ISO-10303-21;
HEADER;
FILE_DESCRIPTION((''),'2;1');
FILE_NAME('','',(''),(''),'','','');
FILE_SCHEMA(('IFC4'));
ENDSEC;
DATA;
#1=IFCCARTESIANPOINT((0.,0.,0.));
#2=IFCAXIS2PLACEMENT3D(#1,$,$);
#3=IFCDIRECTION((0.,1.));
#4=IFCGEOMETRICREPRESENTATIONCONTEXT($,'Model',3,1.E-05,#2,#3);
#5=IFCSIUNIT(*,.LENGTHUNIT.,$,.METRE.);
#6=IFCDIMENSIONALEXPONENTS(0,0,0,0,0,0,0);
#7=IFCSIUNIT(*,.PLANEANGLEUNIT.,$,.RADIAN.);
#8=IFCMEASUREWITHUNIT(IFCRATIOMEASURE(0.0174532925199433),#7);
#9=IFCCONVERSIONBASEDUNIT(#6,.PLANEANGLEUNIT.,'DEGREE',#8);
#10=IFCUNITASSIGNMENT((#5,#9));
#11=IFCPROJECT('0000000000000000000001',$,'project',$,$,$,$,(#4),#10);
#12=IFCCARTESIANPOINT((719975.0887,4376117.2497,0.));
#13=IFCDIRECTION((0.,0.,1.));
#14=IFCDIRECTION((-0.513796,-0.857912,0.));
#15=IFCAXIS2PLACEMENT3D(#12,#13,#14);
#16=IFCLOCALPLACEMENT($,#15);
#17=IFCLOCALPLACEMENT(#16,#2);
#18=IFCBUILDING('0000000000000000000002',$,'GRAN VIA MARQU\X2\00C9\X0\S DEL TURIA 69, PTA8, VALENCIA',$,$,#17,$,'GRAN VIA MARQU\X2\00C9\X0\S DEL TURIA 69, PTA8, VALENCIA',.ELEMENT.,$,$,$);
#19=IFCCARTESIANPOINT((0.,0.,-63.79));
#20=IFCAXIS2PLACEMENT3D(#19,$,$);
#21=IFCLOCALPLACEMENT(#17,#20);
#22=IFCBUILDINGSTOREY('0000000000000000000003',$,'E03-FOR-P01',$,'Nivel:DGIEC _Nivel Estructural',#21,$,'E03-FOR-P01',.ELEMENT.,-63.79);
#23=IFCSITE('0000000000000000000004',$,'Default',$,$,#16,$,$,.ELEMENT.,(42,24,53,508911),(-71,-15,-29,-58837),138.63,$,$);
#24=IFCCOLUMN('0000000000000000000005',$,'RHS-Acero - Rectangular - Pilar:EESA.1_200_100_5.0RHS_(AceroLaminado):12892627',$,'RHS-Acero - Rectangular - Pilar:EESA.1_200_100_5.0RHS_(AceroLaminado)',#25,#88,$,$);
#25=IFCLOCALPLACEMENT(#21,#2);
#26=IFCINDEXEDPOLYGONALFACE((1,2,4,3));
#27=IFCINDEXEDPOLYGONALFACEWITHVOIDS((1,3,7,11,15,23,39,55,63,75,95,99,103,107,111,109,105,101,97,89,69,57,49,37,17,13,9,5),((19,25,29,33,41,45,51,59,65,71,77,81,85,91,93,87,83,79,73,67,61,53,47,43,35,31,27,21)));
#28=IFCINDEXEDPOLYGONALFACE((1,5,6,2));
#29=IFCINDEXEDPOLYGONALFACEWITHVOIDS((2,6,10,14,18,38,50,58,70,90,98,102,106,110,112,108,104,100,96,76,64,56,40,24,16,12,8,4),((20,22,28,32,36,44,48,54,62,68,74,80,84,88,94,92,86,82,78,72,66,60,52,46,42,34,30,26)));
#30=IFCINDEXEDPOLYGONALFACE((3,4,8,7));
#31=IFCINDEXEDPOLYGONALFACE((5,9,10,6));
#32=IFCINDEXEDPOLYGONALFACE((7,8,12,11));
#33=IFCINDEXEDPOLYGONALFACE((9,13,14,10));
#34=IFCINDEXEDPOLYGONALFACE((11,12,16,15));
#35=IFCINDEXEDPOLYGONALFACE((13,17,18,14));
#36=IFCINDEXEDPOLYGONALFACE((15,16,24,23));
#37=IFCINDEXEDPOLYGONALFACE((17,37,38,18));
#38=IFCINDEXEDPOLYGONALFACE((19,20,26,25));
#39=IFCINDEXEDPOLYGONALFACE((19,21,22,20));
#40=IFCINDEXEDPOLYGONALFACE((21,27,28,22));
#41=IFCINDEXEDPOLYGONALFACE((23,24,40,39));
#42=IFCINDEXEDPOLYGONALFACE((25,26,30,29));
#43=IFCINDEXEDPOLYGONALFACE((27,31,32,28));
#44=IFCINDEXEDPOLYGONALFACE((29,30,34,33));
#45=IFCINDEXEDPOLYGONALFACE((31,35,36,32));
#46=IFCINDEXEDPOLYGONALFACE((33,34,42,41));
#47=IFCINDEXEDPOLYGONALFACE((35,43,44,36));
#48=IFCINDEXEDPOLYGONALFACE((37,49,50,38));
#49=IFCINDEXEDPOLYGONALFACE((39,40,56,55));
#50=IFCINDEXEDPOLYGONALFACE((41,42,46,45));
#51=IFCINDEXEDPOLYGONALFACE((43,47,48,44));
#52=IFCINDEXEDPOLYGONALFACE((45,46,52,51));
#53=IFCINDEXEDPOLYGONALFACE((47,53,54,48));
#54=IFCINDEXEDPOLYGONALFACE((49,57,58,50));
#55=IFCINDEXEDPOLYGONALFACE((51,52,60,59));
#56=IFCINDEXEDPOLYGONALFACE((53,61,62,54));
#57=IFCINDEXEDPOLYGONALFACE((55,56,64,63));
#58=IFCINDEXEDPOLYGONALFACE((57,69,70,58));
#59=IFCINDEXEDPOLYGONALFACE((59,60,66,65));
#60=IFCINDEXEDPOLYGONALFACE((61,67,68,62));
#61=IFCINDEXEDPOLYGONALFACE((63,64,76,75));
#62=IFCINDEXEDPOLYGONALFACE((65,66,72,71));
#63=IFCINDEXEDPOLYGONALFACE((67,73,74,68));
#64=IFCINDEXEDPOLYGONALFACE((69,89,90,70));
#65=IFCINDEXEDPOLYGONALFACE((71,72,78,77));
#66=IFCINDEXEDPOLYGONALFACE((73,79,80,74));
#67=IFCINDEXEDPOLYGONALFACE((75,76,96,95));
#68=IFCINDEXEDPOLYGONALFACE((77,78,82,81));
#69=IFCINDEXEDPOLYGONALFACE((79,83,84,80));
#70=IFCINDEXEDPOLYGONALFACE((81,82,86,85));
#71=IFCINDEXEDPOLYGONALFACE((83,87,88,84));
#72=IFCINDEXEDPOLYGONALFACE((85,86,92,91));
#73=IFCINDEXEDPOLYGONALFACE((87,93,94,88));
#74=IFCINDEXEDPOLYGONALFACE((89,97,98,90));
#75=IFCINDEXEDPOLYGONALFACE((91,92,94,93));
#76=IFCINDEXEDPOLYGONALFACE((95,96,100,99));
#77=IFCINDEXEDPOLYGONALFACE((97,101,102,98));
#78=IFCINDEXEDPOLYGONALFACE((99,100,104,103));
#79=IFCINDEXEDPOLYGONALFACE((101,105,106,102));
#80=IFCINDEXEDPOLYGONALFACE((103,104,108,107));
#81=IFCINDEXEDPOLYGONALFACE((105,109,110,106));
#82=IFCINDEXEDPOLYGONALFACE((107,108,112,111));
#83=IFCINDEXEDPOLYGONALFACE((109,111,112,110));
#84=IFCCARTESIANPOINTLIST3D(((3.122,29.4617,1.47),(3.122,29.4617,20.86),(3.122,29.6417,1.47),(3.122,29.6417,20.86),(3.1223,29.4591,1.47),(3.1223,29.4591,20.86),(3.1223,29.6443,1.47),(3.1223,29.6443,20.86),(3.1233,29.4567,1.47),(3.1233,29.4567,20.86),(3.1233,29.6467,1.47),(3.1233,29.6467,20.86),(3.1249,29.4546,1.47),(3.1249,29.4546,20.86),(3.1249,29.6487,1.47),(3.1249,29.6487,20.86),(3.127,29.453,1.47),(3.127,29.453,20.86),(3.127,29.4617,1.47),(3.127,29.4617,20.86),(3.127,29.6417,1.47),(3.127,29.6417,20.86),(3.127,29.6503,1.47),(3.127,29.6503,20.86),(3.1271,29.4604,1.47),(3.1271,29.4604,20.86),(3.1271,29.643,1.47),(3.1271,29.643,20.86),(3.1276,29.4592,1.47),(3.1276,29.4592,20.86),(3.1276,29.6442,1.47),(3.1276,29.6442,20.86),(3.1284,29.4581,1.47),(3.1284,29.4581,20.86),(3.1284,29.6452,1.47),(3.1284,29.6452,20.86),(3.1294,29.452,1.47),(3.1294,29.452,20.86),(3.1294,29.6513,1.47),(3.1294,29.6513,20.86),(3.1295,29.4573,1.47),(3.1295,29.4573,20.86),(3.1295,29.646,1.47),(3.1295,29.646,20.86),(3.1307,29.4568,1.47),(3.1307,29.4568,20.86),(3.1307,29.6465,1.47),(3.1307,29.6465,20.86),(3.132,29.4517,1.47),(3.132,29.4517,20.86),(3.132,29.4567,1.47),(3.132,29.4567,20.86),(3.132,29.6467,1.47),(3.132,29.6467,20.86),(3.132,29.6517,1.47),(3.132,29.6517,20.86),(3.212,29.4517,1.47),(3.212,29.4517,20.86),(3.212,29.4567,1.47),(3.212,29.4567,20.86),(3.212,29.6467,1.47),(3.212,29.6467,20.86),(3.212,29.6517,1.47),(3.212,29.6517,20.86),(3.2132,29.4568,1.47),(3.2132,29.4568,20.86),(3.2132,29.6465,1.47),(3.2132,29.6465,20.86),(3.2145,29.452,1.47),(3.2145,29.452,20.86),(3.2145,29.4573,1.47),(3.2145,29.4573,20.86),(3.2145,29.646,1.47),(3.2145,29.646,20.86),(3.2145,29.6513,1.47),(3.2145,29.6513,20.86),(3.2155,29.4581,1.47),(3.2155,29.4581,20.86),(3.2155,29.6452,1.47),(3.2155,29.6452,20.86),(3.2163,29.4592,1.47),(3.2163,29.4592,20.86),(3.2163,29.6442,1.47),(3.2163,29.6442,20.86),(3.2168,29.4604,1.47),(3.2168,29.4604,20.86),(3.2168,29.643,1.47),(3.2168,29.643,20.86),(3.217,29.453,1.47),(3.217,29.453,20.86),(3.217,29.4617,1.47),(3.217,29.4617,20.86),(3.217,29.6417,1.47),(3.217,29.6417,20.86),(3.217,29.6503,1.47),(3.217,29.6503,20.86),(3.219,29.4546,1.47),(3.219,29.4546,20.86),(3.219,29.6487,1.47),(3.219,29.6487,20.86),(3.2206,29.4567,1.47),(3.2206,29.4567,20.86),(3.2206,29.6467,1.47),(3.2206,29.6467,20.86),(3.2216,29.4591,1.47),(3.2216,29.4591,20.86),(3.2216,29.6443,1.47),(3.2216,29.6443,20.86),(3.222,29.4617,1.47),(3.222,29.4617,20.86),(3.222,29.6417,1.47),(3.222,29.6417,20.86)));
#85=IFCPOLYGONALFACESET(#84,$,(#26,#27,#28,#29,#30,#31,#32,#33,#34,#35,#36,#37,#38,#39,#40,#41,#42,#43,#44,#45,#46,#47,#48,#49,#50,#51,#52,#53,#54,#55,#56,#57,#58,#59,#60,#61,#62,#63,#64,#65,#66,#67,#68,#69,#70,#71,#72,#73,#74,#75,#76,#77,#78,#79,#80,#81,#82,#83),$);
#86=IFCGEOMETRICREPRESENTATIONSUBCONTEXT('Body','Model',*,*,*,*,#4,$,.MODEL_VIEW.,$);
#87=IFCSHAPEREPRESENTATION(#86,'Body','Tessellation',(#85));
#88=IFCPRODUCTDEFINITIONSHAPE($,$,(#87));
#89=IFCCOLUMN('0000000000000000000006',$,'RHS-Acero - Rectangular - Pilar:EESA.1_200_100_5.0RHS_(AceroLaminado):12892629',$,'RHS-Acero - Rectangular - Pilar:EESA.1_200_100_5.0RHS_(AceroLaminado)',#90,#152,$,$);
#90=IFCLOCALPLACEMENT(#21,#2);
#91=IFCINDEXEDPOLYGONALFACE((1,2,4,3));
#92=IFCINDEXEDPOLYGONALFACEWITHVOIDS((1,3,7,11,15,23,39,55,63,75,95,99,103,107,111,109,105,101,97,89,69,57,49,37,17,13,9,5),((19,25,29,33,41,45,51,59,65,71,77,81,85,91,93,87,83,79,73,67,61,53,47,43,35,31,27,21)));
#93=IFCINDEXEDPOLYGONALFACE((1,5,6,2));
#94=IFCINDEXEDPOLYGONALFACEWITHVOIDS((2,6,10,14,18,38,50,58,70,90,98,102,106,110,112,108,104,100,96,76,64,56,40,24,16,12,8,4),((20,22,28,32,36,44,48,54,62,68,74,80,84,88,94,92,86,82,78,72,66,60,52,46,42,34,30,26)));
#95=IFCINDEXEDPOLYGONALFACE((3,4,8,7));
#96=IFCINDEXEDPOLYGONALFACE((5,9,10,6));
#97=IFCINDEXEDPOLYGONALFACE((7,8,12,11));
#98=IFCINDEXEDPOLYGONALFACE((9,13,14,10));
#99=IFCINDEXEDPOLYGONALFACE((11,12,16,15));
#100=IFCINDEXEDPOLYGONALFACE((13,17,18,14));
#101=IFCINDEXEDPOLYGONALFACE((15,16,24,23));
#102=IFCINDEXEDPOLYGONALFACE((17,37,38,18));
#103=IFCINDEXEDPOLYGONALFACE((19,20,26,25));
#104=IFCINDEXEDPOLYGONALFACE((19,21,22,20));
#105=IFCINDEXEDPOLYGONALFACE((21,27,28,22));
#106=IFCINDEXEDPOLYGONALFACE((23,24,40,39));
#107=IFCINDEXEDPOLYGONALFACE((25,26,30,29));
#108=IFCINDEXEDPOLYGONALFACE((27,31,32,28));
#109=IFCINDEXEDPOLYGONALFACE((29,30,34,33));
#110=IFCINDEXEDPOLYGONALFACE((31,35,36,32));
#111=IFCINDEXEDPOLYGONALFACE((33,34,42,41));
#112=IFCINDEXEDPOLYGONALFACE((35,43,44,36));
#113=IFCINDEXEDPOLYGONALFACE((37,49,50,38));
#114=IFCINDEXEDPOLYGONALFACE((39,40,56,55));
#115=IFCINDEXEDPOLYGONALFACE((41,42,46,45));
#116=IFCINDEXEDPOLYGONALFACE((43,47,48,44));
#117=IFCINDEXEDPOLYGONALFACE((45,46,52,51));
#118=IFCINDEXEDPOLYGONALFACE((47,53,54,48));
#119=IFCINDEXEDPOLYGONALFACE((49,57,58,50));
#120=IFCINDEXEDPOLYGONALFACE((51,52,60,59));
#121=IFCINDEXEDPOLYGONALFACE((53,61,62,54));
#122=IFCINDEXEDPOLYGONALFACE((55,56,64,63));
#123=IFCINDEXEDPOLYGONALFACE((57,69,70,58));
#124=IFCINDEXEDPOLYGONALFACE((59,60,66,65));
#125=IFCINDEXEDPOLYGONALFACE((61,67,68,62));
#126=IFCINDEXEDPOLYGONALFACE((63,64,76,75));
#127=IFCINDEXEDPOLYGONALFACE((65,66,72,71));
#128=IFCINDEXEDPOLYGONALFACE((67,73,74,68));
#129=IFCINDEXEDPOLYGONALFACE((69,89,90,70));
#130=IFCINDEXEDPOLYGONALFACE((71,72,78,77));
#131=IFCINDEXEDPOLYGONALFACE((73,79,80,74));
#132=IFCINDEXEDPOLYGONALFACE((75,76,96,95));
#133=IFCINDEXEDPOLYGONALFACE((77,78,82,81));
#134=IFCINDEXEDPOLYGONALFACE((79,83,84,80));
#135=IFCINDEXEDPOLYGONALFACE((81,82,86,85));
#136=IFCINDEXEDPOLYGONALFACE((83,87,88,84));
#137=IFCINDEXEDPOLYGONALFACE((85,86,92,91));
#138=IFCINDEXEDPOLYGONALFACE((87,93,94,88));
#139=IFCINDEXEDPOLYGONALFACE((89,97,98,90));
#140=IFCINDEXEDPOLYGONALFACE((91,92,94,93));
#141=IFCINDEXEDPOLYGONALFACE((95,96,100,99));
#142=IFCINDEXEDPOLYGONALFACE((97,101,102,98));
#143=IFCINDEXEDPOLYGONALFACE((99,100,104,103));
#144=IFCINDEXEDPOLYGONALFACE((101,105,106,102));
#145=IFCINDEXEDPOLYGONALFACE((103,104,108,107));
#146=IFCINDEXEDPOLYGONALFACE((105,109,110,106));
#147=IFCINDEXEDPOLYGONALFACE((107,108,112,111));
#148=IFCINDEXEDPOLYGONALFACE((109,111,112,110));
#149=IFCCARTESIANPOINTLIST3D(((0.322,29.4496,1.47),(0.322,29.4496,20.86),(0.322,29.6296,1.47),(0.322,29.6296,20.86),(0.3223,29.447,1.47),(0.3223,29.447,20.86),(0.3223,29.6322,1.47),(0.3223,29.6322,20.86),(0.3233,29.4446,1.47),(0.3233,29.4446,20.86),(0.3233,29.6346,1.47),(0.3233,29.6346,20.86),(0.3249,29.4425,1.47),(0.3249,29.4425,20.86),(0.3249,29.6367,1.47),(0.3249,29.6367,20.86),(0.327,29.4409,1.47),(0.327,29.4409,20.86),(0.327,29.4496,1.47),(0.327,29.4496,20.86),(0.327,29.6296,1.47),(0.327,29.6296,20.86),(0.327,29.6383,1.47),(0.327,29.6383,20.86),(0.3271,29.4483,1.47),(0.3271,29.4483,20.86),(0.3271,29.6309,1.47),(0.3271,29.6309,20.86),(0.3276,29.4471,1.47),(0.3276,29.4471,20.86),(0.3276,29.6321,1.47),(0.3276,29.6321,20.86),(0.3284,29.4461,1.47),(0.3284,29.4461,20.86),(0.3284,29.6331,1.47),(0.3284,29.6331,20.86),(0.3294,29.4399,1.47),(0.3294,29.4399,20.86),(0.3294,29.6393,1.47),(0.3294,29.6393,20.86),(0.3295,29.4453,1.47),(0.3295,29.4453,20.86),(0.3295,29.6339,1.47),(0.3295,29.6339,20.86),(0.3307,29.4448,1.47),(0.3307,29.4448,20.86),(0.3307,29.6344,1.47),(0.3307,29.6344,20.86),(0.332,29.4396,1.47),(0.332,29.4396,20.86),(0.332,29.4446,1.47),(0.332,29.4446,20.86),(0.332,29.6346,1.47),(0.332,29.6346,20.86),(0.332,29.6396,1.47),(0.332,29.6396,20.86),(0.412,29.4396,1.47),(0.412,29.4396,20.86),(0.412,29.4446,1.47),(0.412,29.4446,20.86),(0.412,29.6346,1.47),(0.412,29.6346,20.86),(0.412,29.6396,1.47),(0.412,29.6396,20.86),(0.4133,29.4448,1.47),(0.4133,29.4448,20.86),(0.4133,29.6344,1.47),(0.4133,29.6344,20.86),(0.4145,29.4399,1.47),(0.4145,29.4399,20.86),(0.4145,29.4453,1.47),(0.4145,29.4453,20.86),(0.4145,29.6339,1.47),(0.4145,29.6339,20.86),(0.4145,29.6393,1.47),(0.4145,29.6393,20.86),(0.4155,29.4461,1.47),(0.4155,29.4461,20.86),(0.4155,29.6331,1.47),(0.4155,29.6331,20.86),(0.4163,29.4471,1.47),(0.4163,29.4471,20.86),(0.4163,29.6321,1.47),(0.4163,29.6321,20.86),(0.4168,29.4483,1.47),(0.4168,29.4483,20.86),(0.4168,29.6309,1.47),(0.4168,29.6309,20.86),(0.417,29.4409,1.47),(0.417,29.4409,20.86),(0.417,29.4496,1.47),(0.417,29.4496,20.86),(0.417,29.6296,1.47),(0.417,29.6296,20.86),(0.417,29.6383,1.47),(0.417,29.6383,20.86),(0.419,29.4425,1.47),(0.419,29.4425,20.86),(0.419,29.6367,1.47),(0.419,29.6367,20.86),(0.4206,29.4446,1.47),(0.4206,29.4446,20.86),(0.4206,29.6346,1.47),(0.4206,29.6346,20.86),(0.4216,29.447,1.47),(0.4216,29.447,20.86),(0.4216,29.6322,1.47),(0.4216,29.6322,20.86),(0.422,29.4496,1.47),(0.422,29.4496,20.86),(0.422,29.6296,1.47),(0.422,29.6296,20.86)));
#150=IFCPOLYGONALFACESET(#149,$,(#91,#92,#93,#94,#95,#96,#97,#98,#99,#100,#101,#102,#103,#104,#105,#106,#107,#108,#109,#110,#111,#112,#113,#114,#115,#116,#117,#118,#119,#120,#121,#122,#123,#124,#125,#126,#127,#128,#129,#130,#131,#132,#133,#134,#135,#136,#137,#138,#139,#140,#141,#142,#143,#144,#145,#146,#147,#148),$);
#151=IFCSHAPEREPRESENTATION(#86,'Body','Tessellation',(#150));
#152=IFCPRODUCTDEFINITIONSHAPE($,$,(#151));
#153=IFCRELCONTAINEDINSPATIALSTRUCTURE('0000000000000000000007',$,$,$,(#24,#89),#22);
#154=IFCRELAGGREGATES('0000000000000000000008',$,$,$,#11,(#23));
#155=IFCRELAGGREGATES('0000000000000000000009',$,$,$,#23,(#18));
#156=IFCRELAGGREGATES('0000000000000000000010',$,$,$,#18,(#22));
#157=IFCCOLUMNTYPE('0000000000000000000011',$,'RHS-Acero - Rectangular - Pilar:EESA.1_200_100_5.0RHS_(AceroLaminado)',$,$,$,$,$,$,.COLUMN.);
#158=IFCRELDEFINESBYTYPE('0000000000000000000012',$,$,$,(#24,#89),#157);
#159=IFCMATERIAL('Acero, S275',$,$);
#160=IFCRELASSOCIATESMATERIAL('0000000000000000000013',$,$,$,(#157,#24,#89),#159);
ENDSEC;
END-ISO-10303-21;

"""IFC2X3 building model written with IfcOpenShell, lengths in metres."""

from ifc_helpers import new_model, entity, si_unit, converted_unit, direction, frame, frame_2d, origin, place, context, subcontext, project, spatial, polyline, circle_curve, parameter, trimmed, segment, composite_curve, outline, extrude, source, transform, mapped, material, type_object, type_shapes, element, save


model = new_model("IFC2X3")

# Units and contexts
model_context = context("Model", 3, precision=1e-05, world=origin(), true_north=direction((0.0, 1.0)))
body_context = subcontext(model_context, "Body", "Model", "MODEL_VIEW")
ifc_project = project(units=[si_unit("LENGTHUNIT", "METRE"), converted_unit("PLANEANGLEUNIT", "DEGREE", entity("IfcRatioMeasure", 0.0174532925199433), si_unit("PLANEANGLEUNIT", "RADIAN"), dimensions=[0, 0, 0, 0, 0, 0, 0])], contexts=[model_context])

# Site, building, storey
site_placement = place(None, frame((719975.0887, 4376117.2497, 0.0), z_axis=(0.0, 0.0, 1.0), x_axis=(-0.513796, -0.857912, 0.0)))
site = spatial("IfcSite", under=ifc_project, at=site_placement, Name="Default", CompositionType="ELEMENT", RefLatitude=(42, 24, 53, 508911), RefLongitude=(-71, -15, -29, -58837), RefElevation=138.63)
building_placement = place(site_placement, origin())
building = spatial("IfcBuilding", under=site, at=building_placement, Name="GRAN VIA MARQUÉS DEL TURIA 69, PTA8, VALENCIA", LongName="GRAN VIA MARQUÉS DEL TURIA 69, PTA8, VALENCIA", CompositionType="ELEMENT")
storey_placement = place(building_placement, frame((0.0, 0.0, -63.79)))
storey = spatial("IfcBuildingStorey", under=building, at=storey_placement, Name="E03-FOR-P01", ObjectType="Nivel:DGIEC _Nivel Estructural", LongName="E03-FOR-P01", CompositionType="ELEMENT", Elevation=-63.79)

# Columns
ifc_material_1 = material(Name="Acero, S275")
column_type_1 = type_object("IfcColumnType", Name="RHS-Acero - Rectangular - Pilar:EESA.1_200_100_5.0RHS_(AceroLaminado)", PredefinedType="COLUMN", material=ifc_material_1)
shared_shape_1 = source(origin(), body_context, "Body", "SweptSolid", [
    extrude(outline(composite_curve([segment(polyline([(-0.04, -0.1), (0.04, -0.1)]), True, "CONTINUOUS"), segment(trimmed(circle_curve(frame_2d((0.04, -0.09), x_axis=(-1.0, 0.0)), 0.01), [parameter(90.0)], [parameter(180.0)], True, "PARAMETER"), True, "CONTINUOUS"), segment(polyline([(0.05, -0.09), (0.05, 0.09)]), True, "CONTINUOUS"), segment(trimmed(circle_curve(frame_2d((0.04, 0.09), x_axis=(-1.0, 0.0)), 0.01), [parameter(180.0)], [parameter(270.0)], True, "PARAMETER"), True, "CONTINUOUS"), segment(polyline([(0.04, 0.1), (-0.04, 0.1)]), True, "CONTINUOUS"), segment(trimmed(circle_curve(frame_2d((-0.04, 0.09), x_axis=(-1.0, 0.0)), 0.01), [parameter(270.0)], [parameter(360.0)], True, "PARAMETER"), True, "CONTINUOUS"), segment(polyline([(-0.05, 0.09), (-0.05, -0.09)]), True, "CONTINUOUS"), segment(trimmed(circle_curve(frame_2d((-0.04, -0.09), x_axis=(-1.0, 0.0)), 0.01), [parameter(360.0)], [parameter(90.0)], True, "PARAMETER"), True, "CONTINUOUS")], self_intersect=False), holes=[composite_curve([segment(trimmed(circle_curve(frame_2d((-0.04, -0.09), x_axis=(-1.0, 0.0)), 0.005), [parameter(0.0)], [parameter(90.0)], True, "PARAMETER"), False, "CONTINUOUS"), segment(polyline([(-0.045, -0.09), (-0.045, 0.09)]), True, "CONTINUOUS"), segment(trimmed(circle_curve(frame_2d((-0.04, 0.09), x_axis=(-1.0, 0.0)), 0.005), [parameter(270.0)], [parameter(0.0)], True, "PARAMETER"), False, "CONTINUOUS"), segment(polyline([(-0.04, 0.095), (0.04, 0.095)]), True, "CONTINUOUS"), segment(trimmed(circle_curve(frame_2d((0.04, 0.09), x_axis=(-1.0, 0.0)), 0.005), [parameter(180.0)], [parameter(270.0)], True, "PARAMETER"), False, "CONTINUOUS"), segment(polyline([(0.045, 0.09), (0.045, -0.09)]), True, "CONTINUOUS"), segment(trimmed(circle_curve(frame_2d((0.04, -0.09), x_axis=(-1.0, 0.0)), 0.005), [parameter(90.0)], [parameter(180.0)], True, "PARAMETER"), False, "CONTINUOUS"), segment(polyline([(0.04, -0.095), (-0.04, -0.095)]), True, "CONTINUOUS")], self_intersect=False)]), frame((0.0, 0.0, -62.32), z_axis=(0.0, 0.0, 1.0), x_axis=(-1.0, 0.0, 0.0)), (0.0, 0.0, 1.0), 19.39),
])
type_shapes(column_type_1, [shared_shape_1])
for number, where, z_axis, x_axis, name in (
    (1, (3.172, 29.5517, 63.79), (0.0, 0.0, 1.0), (-1.0, 0.0, 0.0), "RHS-Acero - Rectangular - Pilar:EESA.1_200_100_5.0RHS_(AceroLaminado):12892627"),
    (2, (0.372, 29.5396, 63.79), (0.0, 0.0, 1.0), (-1.0, 0.0, 0.0), "RHS-Acero - Rectangular - Pilar:EESA.1_200_100_5.0RHS_(AceroLaminado):12892629"),
):
    element("IfcColumn", number, at=place(storey_placement, frame(where, z_axis=z_axis, x_axis=x_axis)), inside=storey, type_object=column_type_1, material=ifc_material_1, Name=name, ObjectType="RHS-Acero - Rectangular - Pilar:EESA.1_200_100_5.0RHS_(AceroLaminado)", context=body_context, shape_type="MappedRepresentation", body=[
        mapped(shared_shape_1, transform((0.0, 0.0, 0.0), scale=1.0)),
    ])

save(model, "model.ifc")
